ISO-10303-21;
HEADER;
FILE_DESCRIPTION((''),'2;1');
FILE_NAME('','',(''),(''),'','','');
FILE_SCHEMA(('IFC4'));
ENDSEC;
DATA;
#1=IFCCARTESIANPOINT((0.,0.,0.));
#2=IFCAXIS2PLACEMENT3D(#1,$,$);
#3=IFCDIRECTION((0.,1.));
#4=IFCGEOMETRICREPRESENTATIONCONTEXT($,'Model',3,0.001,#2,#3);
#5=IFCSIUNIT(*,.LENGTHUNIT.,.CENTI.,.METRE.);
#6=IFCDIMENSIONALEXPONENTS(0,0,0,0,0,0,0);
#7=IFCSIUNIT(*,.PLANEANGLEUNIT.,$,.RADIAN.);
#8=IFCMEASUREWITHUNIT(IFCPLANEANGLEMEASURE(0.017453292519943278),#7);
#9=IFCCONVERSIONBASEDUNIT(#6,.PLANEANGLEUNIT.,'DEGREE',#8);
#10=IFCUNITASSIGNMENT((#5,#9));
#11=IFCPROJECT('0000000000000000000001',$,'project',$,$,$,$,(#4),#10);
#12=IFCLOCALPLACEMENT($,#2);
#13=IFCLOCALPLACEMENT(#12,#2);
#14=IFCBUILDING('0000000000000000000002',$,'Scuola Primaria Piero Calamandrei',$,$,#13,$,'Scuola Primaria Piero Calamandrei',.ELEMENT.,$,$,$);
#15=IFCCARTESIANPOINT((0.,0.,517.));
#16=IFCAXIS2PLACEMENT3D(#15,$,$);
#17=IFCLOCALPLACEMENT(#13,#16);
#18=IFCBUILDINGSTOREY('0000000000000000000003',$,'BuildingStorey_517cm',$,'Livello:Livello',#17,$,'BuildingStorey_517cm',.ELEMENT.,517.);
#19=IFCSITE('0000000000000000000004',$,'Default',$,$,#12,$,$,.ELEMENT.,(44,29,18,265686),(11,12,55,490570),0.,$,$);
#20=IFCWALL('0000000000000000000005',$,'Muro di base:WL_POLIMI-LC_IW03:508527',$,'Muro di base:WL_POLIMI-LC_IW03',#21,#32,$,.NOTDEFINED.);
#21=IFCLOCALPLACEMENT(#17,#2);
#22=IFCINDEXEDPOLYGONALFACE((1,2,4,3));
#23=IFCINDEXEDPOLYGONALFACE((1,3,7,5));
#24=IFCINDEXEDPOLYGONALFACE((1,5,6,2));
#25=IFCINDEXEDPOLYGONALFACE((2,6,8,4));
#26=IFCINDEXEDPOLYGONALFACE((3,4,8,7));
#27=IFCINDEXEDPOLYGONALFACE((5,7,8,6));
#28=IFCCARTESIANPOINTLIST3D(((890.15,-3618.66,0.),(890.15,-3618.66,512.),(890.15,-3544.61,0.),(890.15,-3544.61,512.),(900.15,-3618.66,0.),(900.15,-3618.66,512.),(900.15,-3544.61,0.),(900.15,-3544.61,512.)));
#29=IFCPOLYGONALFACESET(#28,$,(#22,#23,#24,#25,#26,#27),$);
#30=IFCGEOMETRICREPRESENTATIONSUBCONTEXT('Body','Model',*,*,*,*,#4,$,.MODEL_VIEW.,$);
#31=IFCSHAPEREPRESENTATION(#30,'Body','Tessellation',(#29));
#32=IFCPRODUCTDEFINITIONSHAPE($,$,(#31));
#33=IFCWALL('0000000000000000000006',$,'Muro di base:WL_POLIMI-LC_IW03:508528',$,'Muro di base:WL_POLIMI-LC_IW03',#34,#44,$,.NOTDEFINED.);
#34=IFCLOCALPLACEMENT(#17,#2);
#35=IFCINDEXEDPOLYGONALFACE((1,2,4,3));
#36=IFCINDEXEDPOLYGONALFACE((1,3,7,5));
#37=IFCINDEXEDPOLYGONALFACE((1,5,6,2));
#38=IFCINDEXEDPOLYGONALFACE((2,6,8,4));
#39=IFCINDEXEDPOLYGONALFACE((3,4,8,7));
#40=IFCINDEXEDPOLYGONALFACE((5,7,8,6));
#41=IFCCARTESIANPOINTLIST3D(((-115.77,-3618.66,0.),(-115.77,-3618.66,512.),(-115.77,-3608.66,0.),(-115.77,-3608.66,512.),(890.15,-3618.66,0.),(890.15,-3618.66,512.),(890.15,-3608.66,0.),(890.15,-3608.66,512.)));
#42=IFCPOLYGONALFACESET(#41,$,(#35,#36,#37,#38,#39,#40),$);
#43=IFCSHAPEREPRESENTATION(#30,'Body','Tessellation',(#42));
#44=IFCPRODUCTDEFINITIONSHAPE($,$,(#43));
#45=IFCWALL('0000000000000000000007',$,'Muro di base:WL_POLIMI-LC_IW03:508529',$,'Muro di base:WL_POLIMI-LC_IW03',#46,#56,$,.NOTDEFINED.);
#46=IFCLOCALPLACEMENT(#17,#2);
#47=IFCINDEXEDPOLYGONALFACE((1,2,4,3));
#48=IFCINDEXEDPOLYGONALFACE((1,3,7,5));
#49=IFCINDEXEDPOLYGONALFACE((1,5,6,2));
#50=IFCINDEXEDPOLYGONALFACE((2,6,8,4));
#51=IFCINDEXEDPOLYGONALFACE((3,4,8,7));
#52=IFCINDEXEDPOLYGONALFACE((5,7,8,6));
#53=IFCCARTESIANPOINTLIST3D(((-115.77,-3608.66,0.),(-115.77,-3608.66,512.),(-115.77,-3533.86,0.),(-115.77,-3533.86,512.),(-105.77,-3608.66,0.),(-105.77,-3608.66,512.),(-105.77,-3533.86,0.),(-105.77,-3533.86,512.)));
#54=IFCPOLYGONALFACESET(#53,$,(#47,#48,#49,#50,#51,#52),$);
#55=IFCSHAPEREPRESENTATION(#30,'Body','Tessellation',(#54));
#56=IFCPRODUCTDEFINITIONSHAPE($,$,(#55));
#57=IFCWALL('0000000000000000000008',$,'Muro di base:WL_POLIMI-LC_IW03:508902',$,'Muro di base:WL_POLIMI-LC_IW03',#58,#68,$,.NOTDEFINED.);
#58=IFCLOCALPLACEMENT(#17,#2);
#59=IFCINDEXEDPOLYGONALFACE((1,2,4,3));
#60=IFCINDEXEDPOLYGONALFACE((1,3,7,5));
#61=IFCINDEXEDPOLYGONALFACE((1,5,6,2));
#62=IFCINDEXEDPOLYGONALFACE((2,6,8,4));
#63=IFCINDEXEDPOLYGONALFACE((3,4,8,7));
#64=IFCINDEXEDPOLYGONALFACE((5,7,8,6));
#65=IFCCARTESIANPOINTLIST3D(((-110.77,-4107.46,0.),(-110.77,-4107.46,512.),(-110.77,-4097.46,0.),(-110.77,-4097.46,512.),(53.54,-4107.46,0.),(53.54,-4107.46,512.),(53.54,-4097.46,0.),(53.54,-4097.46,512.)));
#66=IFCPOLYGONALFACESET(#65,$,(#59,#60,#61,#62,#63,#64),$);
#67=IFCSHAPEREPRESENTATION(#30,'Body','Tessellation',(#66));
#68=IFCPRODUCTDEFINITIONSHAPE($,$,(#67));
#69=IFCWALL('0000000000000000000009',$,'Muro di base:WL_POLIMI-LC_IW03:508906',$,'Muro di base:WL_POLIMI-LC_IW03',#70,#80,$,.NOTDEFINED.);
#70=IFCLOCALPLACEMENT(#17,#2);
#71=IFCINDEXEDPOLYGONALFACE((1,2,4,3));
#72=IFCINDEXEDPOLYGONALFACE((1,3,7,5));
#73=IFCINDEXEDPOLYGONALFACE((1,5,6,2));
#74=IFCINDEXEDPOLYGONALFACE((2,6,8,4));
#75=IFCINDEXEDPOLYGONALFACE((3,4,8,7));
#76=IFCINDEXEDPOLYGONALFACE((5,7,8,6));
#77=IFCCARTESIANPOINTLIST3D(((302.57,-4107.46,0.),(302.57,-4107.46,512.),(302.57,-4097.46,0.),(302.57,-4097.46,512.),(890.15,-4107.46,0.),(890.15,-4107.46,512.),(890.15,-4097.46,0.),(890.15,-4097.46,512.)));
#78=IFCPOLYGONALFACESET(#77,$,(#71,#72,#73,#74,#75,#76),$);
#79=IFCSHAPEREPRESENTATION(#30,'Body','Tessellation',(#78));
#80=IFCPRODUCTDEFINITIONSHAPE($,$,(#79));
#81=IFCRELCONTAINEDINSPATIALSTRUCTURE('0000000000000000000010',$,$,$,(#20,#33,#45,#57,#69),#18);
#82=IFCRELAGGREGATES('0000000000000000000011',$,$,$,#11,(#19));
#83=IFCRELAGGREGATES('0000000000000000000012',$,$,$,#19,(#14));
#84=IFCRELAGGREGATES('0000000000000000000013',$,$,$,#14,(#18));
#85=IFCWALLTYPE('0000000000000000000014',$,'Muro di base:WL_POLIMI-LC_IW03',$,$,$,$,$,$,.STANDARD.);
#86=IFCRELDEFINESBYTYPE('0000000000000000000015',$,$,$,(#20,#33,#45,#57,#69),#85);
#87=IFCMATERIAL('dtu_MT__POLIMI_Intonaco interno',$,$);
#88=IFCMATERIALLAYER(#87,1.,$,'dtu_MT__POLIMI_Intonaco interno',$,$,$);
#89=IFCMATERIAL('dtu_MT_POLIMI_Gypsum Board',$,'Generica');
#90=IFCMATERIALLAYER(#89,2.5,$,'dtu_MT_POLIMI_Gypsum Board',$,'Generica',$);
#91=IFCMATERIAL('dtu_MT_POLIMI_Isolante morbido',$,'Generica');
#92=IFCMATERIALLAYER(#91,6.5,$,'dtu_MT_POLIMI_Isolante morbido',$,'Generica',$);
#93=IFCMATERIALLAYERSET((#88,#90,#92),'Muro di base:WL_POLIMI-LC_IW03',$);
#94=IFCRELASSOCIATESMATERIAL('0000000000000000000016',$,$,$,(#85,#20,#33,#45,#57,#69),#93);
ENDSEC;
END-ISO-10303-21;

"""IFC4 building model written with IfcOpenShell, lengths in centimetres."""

from ifc_helpers import new_model, entity, si_unit, converted_unit, direction, frame, frame_2d, origin, place, context, subcontext, project, spatial, rectangle, extrude, material, layer, layer_set, layer_usage, type_object, element, save


model = new_model("IFC4")

# Units and contexts
model_context = context("Model", 3, precision=0.001, world=origin(), true_north=direction((0.0, 1.0)))
body_context = subcontext(model_context, "Body", "Model", "MODEL_VIEW")
ifc_project = project(units=[si_unit("LENGTHUNIT", "METRE", prefix="CENTI"), converted_unit("PLANEANGLEUNIT", "DEGREE", entity("IfcPlaneAngleMeasure", 0.017453292519943278), si_unit("PLANEANGLEUNIT", "RADIAN"), dimensions=[0, 0, 0, 0, 0, 0, 0])], contexts=[model_context])

# Site, building, storey
site_placement = place(None, origin())
site = spatial("IfcSite", under=ifc_project, at=site_placement, Name="Default", CompositionType="ELEMENT", RefLatitude=(44, 29, 18, 265686), RefLongitude=(11, 12, 55, 490570), RefElevation=0.0)
building_placement = place(site_placement, origin())
building = spatial("IfcBuilding", under=site, at=building_placement, Name="Scuola Primaria Piero Calamandrei", LongName="Scuola Primaria Piero Calamandrei", CompositionType="ELEMENT")
storey_placement = place(building_placement, frame((0.0, 0.0, 517.0)))
storey = spatial("IfcBuildingStorey", under=building, at=storey_placement, Name="BuildingStorey_517cm", ObjectType="Livello:Livello", LongName="BuildingStorey_517cm", CompositionType="ELEMENT", Elevation=517.0)

# Shared definitions
ifc_material_1 = material(Name="dtu_MT__POLIMI_Intonaco interno")

# Shared definitions
ifc_material_2 = material(Name="dtu_MT_POLIMI_Isolante morbido", Category="Generica")
ifc_material_3 = material(Name="dtu_MT_POLIMI_Gypsum Board", Category="Generica")

# Walls
ifc_layer_1 = layer(ifc_material_1, 1.0, Name="dtu_MT__POLIMI_Intonaco interno")
ifc_layer_2 = layer(ifc_material_3, 2.5, Name="dtu_MT_POLIMI_Gypsum Board", Category="Generica")
ifc_layer_3 = layer(ifc_material_2, 6.5, Name="dtu_MT_POLIMI_Isolante morbido", Category="Generica")
ifc_layer_set_1 = layer_set([ifc_layer_1, ifc_layer_2, ifc_layer_3], Name="Muro di base:WL_POLIMI-LC_IW03")
wall_type_1 = type_object("IfcWallType", Name="Muro di base:WL_POLIMI-LC_IW03", PredefinedType="STANDARD", material=ifc_layer_set_1)
ifc_layer_usage_1 = layer_usage(ifc_layer_set_1, "AXIS2", "NEGATIVE", 5.0)
wall_1_placement = place(storey_placement, frame((895.15, -3618.66, 0.0), z_axis=(0.0, 0.0, 1.0), x_axis=(0.0, 1.0, 0.0)))
element("IfcWall", 1, at=wall_1_placement, inside=storey, type_object=wall_type_1, material=ifc_layer_usage_1, Name="Muro di base:WL_POLIMI-LC_IW03:508527", ObjectType="Muro di base:WL_POLIMI-LC_IW03", PredefinedType="NOTDEFINED", context=body_context, shape_type="SweptSolid", body=[
    extrude(rectangle(XDim=74.05, YDim=10.0, at=frame_2d((37.03, 0.0), x_axis=(-1.0, 0.0))), origin(), (0.0, 0.0, 1.0), 512.0),
])
ifc_layer_usage_2 = layer_usage(ifc_layer_set_1, "AXIS2", "NEGATIVE", 5.0)
wall_2_placement = place(storey_placement, frame((-115.77, -3613.66, 0.0)))
element("IfcWall", 2, at=wall_2_placement, inside=storey, type_object=wall_type_1, material=ifc_layer_usage_2, Name="Muro di base:WL_POLIMI-LC_IW03:508528", ObjectType="Muro di base:WL_POLIMI-LC_IW03", PredefinedType="NOTDEFINED", context=body_context, shape_type="SweptSolid", body=[
    extrude(rectangle(XDim=1005.92, YDim=10.0, at=frame_2d((502.96, 0.0), x_axis=(-1.0, 0.0))), origin(), (0.0, 0.0, 1.0), 512.0),
])
ifc_layer_usage_3 = layer_usage(ifc_layer_set_1, "AXIS2", "NEGATIVE", 5.0)
wall_3_placement = place(storey_placement, frame((-110.77, -3533.86, 0.0), z_axis=(0.0, 0.0, 1.0), x_axis=(0.0, -1.0, 0.0)))
element("IfcWall", 3, at=wall_3_placement, inside=storey, type_object=wall_type_1, material=ifc_layer_usage_3, Name="Muro di base:WL_POLIMI-LC_IW03:508529", ObjectType="Muro di base:WL_POLIMI-LC_IW03", PredefinedType="NOTDEFINED", context=body_context, shape_type="SweptSolid", body=[
    extrude(rectangle(XDim=74.8, YDim=10.0, at=frame_2d((37.4, 0.0), x_axis=(-1.0, 0.0))), origin(), (0.0, 0.0, 1.0), 512.0),
])
ifc_layer_usage_4 = layer_usage(ifc_layer_set_1, "AXIS2", "NEGATIVE", 5.0)
wall_4_placement = place(storey_placement, frame((53.54, -4102.46, 0.0), z_axis=(0.0, 0.0, 1.0), x_axis=(-1.0, 0.0, 0.0)))
element("IfcWall", 4, at=wall_4_placement, inside=storey, type_object=wall_type_1, material=ifc_layer_usage_4, Name="Muro di base:WL_POLIMI-LC_IW03:508902", ObjectType="Muro di base:WL_POLIMI-LC_IW03", PredefinedType="NOTDEFINED", context=body_context, shape_type="SweptSolid", body=[
    extrude(rectangle(XDim=164.31, YDim=10.0, at=frame_2d((82.16, 0.0), x_axis=(-1.0, 0.0))), origin(), (0.0, 0.0, 1.0), 512.0),
])
ifc_layer_usage_5 = layer_usage(ifc_layer_set_1, "AXIS2", "NEGATIVE", 5.0)
wall_5_placement = place(storey_placement, frame((302.57, -4102.46, 0.0)))
element("IfcWall", 5, at=wall_5_placement, inside=storey, type_object=wall_type_1, material=ifc_layer_usage_5, Name="Muro di base:WL_POLIMI-LC_IW03:508906", ObjectType="Muro di base:WL_POLIMI-LC_IW03", PredefinedType="NOTDEFINED", context=body_context, shape_type="SweptSolid", body=[
    extrude(rectangle(XDim=587.58, YDim=10.0, at=frame_2d((293.79, 0.0), x_axis=(-1.0, 0.0))), origin(), (0.0, 0.0, 1.0), 512.0),
])

save(model, "model.ifc")
